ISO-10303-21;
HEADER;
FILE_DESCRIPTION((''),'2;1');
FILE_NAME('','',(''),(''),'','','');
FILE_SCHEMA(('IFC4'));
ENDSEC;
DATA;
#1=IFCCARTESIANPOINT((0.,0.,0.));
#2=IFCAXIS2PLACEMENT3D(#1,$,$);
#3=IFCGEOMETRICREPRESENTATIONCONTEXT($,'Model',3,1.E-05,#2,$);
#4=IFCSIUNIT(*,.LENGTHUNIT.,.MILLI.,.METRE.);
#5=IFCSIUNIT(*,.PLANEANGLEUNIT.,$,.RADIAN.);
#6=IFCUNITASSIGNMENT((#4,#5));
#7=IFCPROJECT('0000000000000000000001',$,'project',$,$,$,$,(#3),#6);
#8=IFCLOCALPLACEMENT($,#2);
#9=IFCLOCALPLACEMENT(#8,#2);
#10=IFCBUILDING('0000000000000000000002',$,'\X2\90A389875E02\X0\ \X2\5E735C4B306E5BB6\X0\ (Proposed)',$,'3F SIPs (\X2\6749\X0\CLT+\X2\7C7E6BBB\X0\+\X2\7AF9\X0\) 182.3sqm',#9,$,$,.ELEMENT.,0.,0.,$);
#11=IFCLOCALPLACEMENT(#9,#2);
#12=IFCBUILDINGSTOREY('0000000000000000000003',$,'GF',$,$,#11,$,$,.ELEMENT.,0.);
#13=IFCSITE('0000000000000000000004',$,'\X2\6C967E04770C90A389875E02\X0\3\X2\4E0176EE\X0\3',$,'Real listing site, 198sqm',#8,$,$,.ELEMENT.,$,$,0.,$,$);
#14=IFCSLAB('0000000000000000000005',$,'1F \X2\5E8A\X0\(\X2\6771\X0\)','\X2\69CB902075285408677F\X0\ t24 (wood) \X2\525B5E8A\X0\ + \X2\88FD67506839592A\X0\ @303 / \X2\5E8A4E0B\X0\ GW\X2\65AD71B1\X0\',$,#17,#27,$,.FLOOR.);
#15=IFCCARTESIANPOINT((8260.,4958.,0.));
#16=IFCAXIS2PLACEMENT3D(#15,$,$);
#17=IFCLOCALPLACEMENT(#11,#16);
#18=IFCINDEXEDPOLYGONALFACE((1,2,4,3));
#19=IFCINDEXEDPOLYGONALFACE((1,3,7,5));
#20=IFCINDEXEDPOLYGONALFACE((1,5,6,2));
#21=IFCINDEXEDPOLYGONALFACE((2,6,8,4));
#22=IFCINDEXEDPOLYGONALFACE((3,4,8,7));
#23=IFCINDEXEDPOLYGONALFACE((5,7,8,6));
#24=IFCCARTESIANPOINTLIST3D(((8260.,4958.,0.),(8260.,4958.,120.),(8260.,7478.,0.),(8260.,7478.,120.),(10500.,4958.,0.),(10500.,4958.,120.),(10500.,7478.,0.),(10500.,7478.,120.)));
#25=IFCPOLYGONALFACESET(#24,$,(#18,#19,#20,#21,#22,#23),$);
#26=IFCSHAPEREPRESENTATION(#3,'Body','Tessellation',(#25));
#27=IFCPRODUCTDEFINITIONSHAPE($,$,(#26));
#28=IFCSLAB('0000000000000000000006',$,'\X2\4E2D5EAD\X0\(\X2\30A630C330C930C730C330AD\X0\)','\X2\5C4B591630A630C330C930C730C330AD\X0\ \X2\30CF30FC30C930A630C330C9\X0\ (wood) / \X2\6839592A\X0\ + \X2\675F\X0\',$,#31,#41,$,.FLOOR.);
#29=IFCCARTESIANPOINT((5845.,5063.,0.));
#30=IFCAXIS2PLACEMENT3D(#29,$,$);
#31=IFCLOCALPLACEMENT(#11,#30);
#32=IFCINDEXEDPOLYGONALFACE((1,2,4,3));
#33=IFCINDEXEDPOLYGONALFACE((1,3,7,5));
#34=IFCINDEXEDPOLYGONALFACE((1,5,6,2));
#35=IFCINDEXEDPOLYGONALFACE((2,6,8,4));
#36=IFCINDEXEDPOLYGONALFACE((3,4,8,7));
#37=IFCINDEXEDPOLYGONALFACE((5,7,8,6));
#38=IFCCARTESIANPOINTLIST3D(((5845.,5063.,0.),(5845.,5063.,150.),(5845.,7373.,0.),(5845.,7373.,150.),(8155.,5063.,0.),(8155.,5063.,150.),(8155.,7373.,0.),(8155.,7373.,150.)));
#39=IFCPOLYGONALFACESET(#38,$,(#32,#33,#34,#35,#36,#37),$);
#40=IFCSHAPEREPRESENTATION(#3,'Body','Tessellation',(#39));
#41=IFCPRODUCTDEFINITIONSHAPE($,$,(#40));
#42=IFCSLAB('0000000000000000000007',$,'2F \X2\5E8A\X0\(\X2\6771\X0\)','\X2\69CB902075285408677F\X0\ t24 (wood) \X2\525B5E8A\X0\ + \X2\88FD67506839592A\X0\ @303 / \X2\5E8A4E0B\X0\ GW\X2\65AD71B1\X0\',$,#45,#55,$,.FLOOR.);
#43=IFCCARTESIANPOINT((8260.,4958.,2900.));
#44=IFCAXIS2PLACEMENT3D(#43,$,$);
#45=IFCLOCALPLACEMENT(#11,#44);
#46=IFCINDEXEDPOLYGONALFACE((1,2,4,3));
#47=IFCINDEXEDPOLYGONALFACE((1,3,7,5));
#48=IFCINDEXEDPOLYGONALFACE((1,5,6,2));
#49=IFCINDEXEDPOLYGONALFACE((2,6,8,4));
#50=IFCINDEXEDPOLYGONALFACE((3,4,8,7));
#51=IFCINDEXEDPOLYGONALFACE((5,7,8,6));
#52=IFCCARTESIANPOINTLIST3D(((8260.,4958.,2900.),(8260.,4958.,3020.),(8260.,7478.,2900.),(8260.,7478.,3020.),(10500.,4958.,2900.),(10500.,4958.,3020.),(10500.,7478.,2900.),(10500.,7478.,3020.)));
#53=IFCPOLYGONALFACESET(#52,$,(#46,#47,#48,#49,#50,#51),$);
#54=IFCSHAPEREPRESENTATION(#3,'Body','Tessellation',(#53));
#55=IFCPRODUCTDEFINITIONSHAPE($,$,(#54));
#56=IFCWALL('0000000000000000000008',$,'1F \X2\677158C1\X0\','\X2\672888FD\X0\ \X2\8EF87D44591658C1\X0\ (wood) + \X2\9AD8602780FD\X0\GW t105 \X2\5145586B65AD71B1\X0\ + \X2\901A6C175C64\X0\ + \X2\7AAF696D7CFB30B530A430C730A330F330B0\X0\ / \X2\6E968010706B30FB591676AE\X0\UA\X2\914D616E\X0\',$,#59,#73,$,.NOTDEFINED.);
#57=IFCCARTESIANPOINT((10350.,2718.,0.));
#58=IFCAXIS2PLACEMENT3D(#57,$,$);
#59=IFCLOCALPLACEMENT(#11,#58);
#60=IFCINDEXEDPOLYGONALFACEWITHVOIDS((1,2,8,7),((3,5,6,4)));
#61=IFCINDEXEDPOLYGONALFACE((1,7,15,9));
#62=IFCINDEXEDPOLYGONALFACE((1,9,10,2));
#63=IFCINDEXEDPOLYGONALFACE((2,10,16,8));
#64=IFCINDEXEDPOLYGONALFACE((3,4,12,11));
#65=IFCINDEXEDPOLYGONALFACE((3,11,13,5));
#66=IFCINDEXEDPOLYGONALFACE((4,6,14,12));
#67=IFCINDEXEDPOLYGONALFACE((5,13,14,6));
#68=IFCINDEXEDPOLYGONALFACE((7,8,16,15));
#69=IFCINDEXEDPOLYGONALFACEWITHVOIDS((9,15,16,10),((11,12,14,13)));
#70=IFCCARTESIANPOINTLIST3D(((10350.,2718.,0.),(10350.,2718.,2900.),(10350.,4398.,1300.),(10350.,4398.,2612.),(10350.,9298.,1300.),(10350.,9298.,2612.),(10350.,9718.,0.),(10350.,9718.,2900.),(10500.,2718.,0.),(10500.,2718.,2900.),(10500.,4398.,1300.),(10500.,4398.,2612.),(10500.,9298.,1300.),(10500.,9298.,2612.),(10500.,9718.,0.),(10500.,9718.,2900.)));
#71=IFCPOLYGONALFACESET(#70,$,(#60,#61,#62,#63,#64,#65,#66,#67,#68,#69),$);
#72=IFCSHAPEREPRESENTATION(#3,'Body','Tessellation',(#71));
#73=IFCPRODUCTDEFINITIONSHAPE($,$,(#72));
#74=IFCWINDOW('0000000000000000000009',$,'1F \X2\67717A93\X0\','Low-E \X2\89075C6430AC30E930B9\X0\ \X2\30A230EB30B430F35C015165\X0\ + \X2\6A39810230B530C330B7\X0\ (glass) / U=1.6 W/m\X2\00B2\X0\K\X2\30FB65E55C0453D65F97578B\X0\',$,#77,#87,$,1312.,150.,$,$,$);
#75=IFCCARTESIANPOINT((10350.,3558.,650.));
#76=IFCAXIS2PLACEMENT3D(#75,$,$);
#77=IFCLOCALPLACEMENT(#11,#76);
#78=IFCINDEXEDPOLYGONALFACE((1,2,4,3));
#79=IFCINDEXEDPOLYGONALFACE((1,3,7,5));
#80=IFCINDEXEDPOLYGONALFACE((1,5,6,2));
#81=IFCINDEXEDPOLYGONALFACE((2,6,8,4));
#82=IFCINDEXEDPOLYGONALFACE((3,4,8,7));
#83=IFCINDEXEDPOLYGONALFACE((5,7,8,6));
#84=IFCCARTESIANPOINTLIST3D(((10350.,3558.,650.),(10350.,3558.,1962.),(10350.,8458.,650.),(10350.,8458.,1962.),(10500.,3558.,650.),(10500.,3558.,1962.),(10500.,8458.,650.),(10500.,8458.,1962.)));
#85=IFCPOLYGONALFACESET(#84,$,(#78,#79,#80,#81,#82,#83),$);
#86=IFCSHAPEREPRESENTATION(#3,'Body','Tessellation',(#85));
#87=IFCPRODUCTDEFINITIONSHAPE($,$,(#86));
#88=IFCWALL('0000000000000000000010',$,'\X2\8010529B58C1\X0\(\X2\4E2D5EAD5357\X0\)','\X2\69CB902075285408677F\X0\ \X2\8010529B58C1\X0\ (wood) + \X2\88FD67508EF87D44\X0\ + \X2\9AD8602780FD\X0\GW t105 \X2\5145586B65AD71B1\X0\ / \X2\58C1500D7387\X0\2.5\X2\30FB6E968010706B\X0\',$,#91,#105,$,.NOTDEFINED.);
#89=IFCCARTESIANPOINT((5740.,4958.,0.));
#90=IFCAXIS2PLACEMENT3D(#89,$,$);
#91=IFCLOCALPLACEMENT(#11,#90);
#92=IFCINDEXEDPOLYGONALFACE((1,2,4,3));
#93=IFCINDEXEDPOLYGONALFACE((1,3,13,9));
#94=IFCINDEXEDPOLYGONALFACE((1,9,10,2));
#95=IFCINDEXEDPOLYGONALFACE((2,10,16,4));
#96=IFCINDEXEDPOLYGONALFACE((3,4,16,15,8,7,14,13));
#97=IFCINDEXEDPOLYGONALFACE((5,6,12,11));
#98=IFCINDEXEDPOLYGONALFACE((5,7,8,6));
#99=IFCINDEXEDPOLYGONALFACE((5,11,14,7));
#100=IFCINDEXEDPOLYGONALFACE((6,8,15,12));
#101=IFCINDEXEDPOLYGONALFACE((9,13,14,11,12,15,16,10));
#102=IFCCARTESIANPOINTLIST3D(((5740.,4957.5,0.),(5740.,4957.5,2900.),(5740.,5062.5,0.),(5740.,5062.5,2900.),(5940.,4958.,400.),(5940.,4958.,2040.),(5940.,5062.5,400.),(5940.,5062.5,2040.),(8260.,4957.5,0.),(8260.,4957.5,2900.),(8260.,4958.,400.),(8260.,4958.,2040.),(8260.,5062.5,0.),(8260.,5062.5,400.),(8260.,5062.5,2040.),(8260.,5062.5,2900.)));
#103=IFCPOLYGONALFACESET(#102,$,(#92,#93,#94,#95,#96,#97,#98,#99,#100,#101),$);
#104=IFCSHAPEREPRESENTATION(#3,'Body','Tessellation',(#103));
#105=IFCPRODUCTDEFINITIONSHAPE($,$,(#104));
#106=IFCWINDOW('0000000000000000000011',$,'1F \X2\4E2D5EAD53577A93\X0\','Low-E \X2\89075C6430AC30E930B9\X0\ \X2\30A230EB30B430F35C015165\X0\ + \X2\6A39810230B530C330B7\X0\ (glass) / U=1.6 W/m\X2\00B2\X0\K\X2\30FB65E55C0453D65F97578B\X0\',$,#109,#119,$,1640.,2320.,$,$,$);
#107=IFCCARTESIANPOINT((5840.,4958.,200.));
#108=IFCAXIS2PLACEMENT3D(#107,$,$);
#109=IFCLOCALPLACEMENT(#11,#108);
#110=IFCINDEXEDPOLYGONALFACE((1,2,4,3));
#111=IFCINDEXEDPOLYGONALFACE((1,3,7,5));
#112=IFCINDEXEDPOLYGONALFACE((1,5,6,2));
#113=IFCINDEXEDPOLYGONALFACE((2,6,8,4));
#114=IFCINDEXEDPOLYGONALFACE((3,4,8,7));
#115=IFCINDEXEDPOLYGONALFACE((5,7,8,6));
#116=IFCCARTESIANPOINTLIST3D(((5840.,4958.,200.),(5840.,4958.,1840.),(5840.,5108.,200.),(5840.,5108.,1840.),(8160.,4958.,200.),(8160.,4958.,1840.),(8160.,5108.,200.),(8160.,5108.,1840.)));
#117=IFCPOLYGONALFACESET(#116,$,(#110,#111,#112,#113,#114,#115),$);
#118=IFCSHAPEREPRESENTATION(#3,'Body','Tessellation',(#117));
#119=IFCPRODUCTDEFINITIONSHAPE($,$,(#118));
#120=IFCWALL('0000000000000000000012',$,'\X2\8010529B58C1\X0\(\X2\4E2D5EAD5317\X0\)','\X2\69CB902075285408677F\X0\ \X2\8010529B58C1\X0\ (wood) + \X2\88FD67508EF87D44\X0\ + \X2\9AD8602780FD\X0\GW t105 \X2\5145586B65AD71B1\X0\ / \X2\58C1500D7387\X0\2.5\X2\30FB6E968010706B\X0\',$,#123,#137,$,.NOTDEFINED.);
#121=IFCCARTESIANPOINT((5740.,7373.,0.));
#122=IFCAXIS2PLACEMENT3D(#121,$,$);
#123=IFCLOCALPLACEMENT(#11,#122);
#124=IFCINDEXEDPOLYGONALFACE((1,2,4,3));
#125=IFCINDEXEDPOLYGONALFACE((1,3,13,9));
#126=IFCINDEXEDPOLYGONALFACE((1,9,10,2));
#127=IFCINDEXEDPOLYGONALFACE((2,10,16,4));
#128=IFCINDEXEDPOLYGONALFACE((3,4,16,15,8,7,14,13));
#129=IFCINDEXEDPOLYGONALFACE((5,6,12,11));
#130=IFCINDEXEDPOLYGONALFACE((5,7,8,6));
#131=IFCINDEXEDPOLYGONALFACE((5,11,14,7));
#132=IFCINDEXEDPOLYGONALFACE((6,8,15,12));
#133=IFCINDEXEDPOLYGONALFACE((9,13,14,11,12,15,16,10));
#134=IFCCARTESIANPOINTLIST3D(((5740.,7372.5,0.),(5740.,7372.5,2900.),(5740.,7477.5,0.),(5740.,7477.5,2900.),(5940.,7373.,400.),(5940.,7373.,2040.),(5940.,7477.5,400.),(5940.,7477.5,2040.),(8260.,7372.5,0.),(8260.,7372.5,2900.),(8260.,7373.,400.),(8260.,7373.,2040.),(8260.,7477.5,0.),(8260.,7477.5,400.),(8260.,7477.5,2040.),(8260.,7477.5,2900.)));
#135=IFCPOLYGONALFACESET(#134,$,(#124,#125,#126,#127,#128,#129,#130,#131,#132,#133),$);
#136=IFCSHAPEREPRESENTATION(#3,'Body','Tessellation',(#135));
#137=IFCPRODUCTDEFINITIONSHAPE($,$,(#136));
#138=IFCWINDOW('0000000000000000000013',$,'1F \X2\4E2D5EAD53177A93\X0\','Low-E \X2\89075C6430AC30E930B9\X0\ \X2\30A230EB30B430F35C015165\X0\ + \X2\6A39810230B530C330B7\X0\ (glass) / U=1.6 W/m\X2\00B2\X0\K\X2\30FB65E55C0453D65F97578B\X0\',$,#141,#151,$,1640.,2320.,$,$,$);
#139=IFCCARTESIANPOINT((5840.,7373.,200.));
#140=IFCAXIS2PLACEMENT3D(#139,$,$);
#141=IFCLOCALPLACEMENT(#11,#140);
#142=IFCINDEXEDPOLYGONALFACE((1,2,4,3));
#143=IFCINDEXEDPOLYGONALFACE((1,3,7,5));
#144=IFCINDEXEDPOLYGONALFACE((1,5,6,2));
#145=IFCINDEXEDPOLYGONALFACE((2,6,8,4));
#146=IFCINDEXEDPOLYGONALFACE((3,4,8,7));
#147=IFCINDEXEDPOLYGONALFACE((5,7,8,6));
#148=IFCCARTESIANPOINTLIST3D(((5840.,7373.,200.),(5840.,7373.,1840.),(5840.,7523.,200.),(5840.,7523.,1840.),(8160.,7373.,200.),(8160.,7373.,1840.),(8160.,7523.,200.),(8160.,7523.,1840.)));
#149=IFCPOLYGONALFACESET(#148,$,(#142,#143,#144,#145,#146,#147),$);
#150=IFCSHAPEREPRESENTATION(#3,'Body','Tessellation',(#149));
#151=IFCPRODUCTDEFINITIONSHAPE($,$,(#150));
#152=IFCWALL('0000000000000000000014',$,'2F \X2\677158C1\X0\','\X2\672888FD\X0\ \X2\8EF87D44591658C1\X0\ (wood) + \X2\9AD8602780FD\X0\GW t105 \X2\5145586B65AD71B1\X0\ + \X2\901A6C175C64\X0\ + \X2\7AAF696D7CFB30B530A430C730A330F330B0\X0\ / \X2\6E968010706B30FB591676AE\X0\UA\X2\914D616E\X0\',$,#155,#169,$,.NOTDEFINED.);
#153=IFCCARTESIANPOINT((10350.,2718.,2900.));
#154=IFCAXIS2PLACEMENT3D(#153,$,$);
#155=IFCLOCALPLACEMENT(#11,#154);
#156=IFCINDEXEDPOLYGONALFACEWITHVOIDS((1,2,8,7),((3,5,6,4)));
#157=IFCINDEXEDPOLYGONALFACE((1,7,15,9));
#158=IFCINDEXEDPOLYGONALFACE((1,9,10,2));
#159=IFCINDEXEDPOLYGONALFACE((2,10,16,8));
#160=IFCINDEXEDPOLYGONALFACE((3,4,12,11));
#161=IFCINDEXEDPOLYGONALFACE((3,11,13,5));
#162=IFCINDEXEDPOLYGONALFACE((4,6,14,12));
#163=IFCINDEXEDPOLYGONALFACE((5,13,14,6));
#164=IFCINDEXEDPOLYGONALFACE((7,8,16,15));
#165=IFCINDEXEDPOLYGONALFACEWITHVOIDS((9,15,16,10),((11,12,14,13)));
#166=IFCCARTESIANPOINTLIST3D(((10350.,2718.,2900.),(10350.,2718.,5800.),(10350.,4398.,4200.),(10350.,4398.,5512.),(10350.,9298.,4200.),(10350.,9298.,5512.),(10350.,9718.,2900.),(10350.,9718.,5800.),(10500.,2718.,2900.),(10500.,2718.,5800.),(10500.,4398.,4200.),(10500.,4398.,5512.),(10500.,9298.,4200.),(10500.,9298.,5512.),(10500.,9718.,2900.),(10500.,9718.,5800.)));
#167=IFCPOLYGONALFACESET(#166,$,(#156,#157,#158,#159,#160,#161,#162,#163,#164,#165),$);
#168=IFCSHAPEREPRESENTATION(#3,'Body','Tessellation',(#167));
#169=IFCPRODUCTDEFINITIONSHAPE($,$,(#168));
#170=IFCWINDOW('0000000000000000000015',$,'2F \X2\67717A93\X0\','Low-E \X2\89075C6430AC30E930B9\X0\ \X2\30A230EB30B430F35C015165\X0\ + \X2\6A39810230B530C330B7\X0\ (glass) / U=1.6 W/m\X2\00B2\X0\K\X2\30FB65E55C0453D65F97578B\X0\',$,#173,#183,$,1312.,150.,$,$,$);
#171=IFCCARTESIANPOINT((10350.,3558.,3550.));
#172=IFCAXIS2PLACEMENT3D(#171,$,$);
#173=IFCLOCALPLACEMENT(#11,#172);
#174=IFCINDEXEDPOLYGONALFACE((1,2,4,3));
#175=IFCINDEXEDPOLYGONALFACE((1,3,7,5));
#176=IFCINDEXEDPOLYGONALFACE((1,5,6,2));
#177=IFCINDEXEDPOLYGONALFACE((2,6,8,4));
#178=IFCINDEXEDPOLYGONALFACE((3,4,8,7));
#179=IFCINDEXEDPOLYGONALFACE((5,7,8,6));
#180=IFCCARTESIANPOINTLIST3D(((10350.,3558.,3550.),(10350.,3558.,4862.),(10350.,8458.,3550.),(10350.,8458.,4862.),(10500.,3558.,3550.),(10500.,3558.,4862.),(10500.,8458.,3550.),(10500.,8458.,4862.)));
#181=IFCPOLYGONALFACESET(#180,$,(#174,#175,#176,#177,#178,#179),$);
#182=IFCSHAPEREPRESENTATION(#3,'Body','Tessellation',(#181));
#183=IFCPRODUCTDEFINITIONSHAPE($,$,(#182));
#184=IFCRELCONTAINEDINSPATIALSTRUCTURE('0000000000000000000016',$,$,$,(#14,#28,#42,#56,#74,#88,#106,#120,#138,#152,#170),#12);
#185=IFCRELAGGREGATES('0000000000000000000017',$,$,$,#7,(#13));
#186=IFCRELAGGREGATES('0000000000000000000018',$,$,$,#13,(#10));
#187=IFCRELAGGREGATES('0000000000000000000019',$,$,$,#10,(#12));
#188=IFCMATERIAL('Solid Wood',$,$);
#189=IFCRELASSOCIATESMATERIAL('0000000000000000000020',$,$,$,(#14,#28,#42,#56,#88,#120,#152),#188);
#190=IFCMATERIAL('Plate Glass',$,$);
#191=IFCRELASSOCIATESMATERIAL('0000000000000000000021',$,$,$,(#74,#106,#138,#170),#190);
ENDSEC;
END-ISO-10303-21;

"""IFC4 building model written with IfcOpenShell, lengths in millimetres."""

from ifc_helpers import new_model, si_unit, frame, frame_2d, origin, place, context, project, spatial, rectangle, extrude, material, element, fill, save


model = new_model("IFC4")

# Units and contexts
model_context = context("Model", 3, precision=1e-05, world=origin())
ifc_project = project(units=[si_unit("LENGTHUNIT", "METRE", prefix="MILLI"), si_unit("PLANEANGLEUNIT", "RADIAN")], contexts=[model_context])

# Site, building, storey
site_placement = place(None, origin())
site = spatial("IfcSite", under=ifc_project, at=site_placement, Name="沖縄県那覇市3丁目3", ObjectType="Real listing site, 198sqm", CompositionType="ELEMENT", RefElevation=0.0)
building_placement = place(site_placement, origin())
building = spatial("IfcBuilding", under=site, at=building_placement, Name="那覇市 平屋の家 (Proposed)", ObjectType="3F SIPs (杉CLT+籾殻+竹) 182.3sqm", CompositionType="ELEMENT", ElevationOfRefHeight=0.0, ElevationOfTerrain=0.0)
storey_placement = place(building_placement, origin())
storey = spatial("IfcBuildingStorey", under=building, at=storey_placement, Name="GF", CompositionType="ELEMENT", Elevation=0.0)

# Slabs
ifc_material_1 = material(Name="Solid Wood")
slab_1_placement = place(storey_placement, frame((8260.0, 4958.0, 0.0)))
element("IfcSlab", 1, at=slab_1_placement, inside=storey, material=ifc_material_1, Name="1F 床(東)", Description="構造用合板 t24 (wood) 剛床 + 製材根太 @303 / 床下 GW断熱", PredefinedType="FLOOR", context=model_context, shape_type="SweptSolid", body=[
    extrude(rectangle(XDim=2240.0, YDim=2520.0, at=frame_2d((1120.0, 1260.0))), frame((8260.0, 4958.0, 0.0)), (0.0, 0.0, 1.0), 120.0),
])
slab_2_placement = place(storey_placement, frame((5845.0, 5063.0, 0.0)))
element("IfcSlab", 2, at=slab_2_placement, inside=storey, material=ifc_material_1, Name="中庭(ウッドデッキ)", Description="屋外ウッドデッキ ハードウッド (wood) / 根太 + 束", PredefinedType="FLOOR", context=model_context, shape_type="SweptSolid", body=[
    extrude(rectangle(XDim=2310.0, YDim=2310.0, at=frame_2d((1155.0, 1155.0))), frame((5845.0, 5063.0, 0.0)), (0.0, 0.0, 1.0), 150.0),
])
slab_3_placement = place(storey_placement, frame((8260.0, 4958.0, 2900.0)))
element("IfcSlab", 3, at=slab_3_placement, inside=storey, material=ifc_material_1, Name="2F 床(東)", Description="構造用合板 t24 (wood) 剛床 + 製材根太 @303 / 床下 GW断熱", PredefinedType="FLOOR", context=model_context, shape_type="SweptSolid", body=[
    extrude(rectangle(XDim=2240.0, YDim=2520.0, at=frame_2d((1120.0, 1260.0))), frame((8260.0, 4958.0, 2900.0)), (0.0, 0.0, 1.0), 120.0),
])

# Walls, openings, windows
wall_1_placement = place(storey_placement, frame((10350.0, 2718.0, 0.0)))
wall_1 = element("IfcWall", 4, at=wall_1_placement, inside=storey, material=ifc_material_1, Name="1F 東壁", Description="木製 軸組外壁 (wood) + 高性能GW t105 充填断熱 + 通気層 + 窯業系サイディング / 準耐火・外皮UA配慮", PredefinedType="NOTDEFINED", context=model_context, shape_type="SweptSolid", body=[
    extrude(rectangle(XDim=150.0, YDim=7000.0, at=frame_2d((75.0, 3500.0))), frame((10350.0, 2718.0, 0.0)), (0.0, 0.0, 1.0), 2900.0),
])
opening_1_placement = place(storey_placement, frame((10350.0, 3558.0, 650.0)))
opening_1 = element("IfcOpeningElement", 5, at=opening_1_placement, cuts=wall_1, PredefinedType="NOTDEFINED", context=model_context, shape_type="SweptSolid", body=[
    extrude(rectangle(XDim=150.0, YDim=4900.0, at=frame_2d((75.0, 2450.0))), frame((10350.0, 3558.0, 650.0)), (0.0, 0.0, 1.0), 1312.0),
])
ifc_material_2 = material(Name="Plate Glass")
window_1_placement = place(storey_placement, frame((10350.0, 3558.0, 650.0)))
window_1 = element("IfcWindow", 6, at=window_1_placement, inside=storey, material=ifc_material_2, Name="1F 東窓", Description="Low-E 複層ガラス アルゴン封入 + 樹脂サッシ (glass) / U=1.6 W/m²K・日射取得型", OverallHeight=1312.0, OverallWidth=150.0, context=model_context, shape_type="SweptSolid", body=[
    extrude(rectangle(XDim=150.0, YDim=4900.0, at=frame_2d((75.0, 2450.0))), frame((10350.0, 3558.0, 650.0)), (0.0, 0.0, 1.0), 1312.0),
])
fill(opening_1, window_1)
wall_2_placement = place(storey_placement, frame((5740.0, 4958.0, 0.0)))
wall_2 = element("IfcWall", 7, at=wall_2_placement, inside=storey, material=ifc_material_1, Name="耐力壁(中庭南)", Description="構造用合板 耐力壁 (wood) + 製材軸組 + 高性能GW t105 充填断熱 / 壁倍率2.5・準耐火", PredefinedType="NOTDEFINED", context=model_context, shape_type="SweptSolid", body=[
    extrude(rectangle(XDim=2520.0, YDim=105.0, at=frame_2d((1260.0, 52.0))), frame((5740.0, 4958.0, 0.0)), (0.0, 0.0, 1.0), 2900.0),
])
opening_2_placement = place(storey_placement, frame((5840.0, 4958.0, 200.0)))
opening_2 = element("IfcOpeningElement", 8, at=opening_2_placement, cuts=wall_2, PredefinedType="NOTDEFINED", context=model_context, shape_type="SweptSolid", body=[
    extrude(rectangle(XDim=2320.0, YDim=150.0, at=frame_2d((1160.0, 75.0))), frame((5840.0, 4958.0, 200.0)), (0.0, 0.0, 1.0), 1640.0),
])
window_2_placement = place(storey_placement, frame((5840.0, 4958.0, 200.0)))
window_2 = element("IfcWindow", 9, at=window_2_placement, inside=storey, material=ifc_material_2, Name="1F 中庭南窓", Description="Low-E 複層ガラス アルゴン封入 + 樹脂サッシ (glass) / U=1.6 W/m²K・日射取得型", OverallHeight=1640.0, OverallWidth=2320.0, context=model_context, shape_type="SweptSolid", body=[
    extrude(rectangle(XDim=2320.0, YDim=150.0, at=frame_2d((1160.0, 75.0))), frame((5840.0, 4958.0, 200.0)), (0.0, 0.0, 1.0), 1640.0),
])
fill(opening_2, window_2)
wall_3_placement = place(storey_placement, frame((5740.0, 7373.0, 0.0)))
wall_3 = element("IfcWall", 10, at=wall_3_placement, inside=storey, material=ifc_material_1, Name="耐力壁(中庭北)", Description="構造用合板 耐力壁 (wood) + 製材軸組 + 高性能GW t105 充填断熱 / 壁倍率2.5・準耐火", PredefinedType="NOTDEFINED", context=model_context, shape_type="SweptSolid", body=[
    extrude(rectangle(XDim=2520.0, YDim=105.0, at=frame_2d((1260.0, 52.0))), frame((5740.0, 7373.0, 0.0)), (0.0, 0.0, 1.0), 2900.0),
])
opening_3_placement = place(storey_placement, frame((5840.0, 7373.0, 200.0)))
opening_3 = element("IfcOpeningElement", 11, at=opening_3_placement, cuts=wall_3, PredefinedType="NOTDEFINED", context=model_context, shape_type="SweptSolid", body=[
    extrude(rectangle(XDim=2320.0, YDim=150.0, at=frame_2d((1160.0, 75.0))), frame((5840.0, 7373.0, 200.0)), (0.0, 0.0, 1.0), 1640.0),
])
window_3_placement = place(storey_placement, frame((5840.0, 7373.0, 200.0)))
window_3 = element("IfcWindow", 12, at=window_3_placement, inside=storey, material=ifc_material_2, Name="1F 中庭北窓", Description="Low-E 複層ガラス アルゴン封入 + 樹脂サッシ (glass) / U=1.6 W/m²K・日射取得型", OverallHeight=1640.0, OverallWidth=2320.0, context=model_context, shape_type="SweptSolid", body=[
    extrude(rectangle(XDim=2320.0, YDim=150.0, at=frame_2d((1160.0, 75.0))), frame((5840.0, 7373.0, 200.0)), (0.0, 0.0, 1.0), 1640.0),
])
fill(opening_3, window_3)

# Wall, opening, window
wall_4_placement = place(storey_placement, frame((10350.0, 2718.0, 2900.0)))
wall_4 = element("IfcWall", 13, at=wall_4_placement, inside=storey, material=ifc_material_1, Name="2F 東壁", Description="木製 軸組外壁 (wood) + 高性能GW t105 充填断熱 + 通気層 + 窯業系サイディング / 準耐火・外皮UA配慮", PredefinedType="NOTDEFINED", context=model_context, shape_type="SweptSolid", body=[
    extrude(rectangle(XDim=150.0, YDim=7000.0, at=frame_2d((75.0, 3500.0))), frame((10350.0, 2718.0, 2900.0)), (0.0, 0.0, 1.0), 2900.0),
])
opening_4_placement = place(storey_placement, frame((10350.0, 3558.0, 3550.0)))
opening_4 = element("IfcOpeningElement", 14, at=opening_4_placement, cuts=wall_4, PredefinedType="NOTDEFINED", context=model_context, shape_type="SweptSolid", body=[
    extrude(rectangle(XDim=150.0, YDim=4900.0, at=frame_2d((75.0, 2450.0))), frame((10350.0, 3558.0, 3550.0)), (0.0, 0.0, 1.0), 1312.0),
])
window_4_placement = place(storey_placement, frame((10350.0, 3558.0, 3550.0)))
window_4 = element("IfcWindow", 15, at=window_4_placement, inside=storey, material=ifc_material_2, Name="2F 東窓", Description="Low-E 複層ガラス アルゴン封入 + 樹脂サッシ (glass) / U=1.6 W/m²K・日射取得型", OverallHeight=1312.0, OverallWidth=150.0, context=model_context, shape_type="SweptSolid", body=[
    extrude(rectangle(XDim=150.0, YDim=4900.0, at=frame_2d((75.0, 2450.0))), frame((10350.0, 3558.0, 3550.0)), (0.0, 0.0, 1.0), 1312.0),
])
fill(opening_4, window_4)

save(model, "model.ifc")
